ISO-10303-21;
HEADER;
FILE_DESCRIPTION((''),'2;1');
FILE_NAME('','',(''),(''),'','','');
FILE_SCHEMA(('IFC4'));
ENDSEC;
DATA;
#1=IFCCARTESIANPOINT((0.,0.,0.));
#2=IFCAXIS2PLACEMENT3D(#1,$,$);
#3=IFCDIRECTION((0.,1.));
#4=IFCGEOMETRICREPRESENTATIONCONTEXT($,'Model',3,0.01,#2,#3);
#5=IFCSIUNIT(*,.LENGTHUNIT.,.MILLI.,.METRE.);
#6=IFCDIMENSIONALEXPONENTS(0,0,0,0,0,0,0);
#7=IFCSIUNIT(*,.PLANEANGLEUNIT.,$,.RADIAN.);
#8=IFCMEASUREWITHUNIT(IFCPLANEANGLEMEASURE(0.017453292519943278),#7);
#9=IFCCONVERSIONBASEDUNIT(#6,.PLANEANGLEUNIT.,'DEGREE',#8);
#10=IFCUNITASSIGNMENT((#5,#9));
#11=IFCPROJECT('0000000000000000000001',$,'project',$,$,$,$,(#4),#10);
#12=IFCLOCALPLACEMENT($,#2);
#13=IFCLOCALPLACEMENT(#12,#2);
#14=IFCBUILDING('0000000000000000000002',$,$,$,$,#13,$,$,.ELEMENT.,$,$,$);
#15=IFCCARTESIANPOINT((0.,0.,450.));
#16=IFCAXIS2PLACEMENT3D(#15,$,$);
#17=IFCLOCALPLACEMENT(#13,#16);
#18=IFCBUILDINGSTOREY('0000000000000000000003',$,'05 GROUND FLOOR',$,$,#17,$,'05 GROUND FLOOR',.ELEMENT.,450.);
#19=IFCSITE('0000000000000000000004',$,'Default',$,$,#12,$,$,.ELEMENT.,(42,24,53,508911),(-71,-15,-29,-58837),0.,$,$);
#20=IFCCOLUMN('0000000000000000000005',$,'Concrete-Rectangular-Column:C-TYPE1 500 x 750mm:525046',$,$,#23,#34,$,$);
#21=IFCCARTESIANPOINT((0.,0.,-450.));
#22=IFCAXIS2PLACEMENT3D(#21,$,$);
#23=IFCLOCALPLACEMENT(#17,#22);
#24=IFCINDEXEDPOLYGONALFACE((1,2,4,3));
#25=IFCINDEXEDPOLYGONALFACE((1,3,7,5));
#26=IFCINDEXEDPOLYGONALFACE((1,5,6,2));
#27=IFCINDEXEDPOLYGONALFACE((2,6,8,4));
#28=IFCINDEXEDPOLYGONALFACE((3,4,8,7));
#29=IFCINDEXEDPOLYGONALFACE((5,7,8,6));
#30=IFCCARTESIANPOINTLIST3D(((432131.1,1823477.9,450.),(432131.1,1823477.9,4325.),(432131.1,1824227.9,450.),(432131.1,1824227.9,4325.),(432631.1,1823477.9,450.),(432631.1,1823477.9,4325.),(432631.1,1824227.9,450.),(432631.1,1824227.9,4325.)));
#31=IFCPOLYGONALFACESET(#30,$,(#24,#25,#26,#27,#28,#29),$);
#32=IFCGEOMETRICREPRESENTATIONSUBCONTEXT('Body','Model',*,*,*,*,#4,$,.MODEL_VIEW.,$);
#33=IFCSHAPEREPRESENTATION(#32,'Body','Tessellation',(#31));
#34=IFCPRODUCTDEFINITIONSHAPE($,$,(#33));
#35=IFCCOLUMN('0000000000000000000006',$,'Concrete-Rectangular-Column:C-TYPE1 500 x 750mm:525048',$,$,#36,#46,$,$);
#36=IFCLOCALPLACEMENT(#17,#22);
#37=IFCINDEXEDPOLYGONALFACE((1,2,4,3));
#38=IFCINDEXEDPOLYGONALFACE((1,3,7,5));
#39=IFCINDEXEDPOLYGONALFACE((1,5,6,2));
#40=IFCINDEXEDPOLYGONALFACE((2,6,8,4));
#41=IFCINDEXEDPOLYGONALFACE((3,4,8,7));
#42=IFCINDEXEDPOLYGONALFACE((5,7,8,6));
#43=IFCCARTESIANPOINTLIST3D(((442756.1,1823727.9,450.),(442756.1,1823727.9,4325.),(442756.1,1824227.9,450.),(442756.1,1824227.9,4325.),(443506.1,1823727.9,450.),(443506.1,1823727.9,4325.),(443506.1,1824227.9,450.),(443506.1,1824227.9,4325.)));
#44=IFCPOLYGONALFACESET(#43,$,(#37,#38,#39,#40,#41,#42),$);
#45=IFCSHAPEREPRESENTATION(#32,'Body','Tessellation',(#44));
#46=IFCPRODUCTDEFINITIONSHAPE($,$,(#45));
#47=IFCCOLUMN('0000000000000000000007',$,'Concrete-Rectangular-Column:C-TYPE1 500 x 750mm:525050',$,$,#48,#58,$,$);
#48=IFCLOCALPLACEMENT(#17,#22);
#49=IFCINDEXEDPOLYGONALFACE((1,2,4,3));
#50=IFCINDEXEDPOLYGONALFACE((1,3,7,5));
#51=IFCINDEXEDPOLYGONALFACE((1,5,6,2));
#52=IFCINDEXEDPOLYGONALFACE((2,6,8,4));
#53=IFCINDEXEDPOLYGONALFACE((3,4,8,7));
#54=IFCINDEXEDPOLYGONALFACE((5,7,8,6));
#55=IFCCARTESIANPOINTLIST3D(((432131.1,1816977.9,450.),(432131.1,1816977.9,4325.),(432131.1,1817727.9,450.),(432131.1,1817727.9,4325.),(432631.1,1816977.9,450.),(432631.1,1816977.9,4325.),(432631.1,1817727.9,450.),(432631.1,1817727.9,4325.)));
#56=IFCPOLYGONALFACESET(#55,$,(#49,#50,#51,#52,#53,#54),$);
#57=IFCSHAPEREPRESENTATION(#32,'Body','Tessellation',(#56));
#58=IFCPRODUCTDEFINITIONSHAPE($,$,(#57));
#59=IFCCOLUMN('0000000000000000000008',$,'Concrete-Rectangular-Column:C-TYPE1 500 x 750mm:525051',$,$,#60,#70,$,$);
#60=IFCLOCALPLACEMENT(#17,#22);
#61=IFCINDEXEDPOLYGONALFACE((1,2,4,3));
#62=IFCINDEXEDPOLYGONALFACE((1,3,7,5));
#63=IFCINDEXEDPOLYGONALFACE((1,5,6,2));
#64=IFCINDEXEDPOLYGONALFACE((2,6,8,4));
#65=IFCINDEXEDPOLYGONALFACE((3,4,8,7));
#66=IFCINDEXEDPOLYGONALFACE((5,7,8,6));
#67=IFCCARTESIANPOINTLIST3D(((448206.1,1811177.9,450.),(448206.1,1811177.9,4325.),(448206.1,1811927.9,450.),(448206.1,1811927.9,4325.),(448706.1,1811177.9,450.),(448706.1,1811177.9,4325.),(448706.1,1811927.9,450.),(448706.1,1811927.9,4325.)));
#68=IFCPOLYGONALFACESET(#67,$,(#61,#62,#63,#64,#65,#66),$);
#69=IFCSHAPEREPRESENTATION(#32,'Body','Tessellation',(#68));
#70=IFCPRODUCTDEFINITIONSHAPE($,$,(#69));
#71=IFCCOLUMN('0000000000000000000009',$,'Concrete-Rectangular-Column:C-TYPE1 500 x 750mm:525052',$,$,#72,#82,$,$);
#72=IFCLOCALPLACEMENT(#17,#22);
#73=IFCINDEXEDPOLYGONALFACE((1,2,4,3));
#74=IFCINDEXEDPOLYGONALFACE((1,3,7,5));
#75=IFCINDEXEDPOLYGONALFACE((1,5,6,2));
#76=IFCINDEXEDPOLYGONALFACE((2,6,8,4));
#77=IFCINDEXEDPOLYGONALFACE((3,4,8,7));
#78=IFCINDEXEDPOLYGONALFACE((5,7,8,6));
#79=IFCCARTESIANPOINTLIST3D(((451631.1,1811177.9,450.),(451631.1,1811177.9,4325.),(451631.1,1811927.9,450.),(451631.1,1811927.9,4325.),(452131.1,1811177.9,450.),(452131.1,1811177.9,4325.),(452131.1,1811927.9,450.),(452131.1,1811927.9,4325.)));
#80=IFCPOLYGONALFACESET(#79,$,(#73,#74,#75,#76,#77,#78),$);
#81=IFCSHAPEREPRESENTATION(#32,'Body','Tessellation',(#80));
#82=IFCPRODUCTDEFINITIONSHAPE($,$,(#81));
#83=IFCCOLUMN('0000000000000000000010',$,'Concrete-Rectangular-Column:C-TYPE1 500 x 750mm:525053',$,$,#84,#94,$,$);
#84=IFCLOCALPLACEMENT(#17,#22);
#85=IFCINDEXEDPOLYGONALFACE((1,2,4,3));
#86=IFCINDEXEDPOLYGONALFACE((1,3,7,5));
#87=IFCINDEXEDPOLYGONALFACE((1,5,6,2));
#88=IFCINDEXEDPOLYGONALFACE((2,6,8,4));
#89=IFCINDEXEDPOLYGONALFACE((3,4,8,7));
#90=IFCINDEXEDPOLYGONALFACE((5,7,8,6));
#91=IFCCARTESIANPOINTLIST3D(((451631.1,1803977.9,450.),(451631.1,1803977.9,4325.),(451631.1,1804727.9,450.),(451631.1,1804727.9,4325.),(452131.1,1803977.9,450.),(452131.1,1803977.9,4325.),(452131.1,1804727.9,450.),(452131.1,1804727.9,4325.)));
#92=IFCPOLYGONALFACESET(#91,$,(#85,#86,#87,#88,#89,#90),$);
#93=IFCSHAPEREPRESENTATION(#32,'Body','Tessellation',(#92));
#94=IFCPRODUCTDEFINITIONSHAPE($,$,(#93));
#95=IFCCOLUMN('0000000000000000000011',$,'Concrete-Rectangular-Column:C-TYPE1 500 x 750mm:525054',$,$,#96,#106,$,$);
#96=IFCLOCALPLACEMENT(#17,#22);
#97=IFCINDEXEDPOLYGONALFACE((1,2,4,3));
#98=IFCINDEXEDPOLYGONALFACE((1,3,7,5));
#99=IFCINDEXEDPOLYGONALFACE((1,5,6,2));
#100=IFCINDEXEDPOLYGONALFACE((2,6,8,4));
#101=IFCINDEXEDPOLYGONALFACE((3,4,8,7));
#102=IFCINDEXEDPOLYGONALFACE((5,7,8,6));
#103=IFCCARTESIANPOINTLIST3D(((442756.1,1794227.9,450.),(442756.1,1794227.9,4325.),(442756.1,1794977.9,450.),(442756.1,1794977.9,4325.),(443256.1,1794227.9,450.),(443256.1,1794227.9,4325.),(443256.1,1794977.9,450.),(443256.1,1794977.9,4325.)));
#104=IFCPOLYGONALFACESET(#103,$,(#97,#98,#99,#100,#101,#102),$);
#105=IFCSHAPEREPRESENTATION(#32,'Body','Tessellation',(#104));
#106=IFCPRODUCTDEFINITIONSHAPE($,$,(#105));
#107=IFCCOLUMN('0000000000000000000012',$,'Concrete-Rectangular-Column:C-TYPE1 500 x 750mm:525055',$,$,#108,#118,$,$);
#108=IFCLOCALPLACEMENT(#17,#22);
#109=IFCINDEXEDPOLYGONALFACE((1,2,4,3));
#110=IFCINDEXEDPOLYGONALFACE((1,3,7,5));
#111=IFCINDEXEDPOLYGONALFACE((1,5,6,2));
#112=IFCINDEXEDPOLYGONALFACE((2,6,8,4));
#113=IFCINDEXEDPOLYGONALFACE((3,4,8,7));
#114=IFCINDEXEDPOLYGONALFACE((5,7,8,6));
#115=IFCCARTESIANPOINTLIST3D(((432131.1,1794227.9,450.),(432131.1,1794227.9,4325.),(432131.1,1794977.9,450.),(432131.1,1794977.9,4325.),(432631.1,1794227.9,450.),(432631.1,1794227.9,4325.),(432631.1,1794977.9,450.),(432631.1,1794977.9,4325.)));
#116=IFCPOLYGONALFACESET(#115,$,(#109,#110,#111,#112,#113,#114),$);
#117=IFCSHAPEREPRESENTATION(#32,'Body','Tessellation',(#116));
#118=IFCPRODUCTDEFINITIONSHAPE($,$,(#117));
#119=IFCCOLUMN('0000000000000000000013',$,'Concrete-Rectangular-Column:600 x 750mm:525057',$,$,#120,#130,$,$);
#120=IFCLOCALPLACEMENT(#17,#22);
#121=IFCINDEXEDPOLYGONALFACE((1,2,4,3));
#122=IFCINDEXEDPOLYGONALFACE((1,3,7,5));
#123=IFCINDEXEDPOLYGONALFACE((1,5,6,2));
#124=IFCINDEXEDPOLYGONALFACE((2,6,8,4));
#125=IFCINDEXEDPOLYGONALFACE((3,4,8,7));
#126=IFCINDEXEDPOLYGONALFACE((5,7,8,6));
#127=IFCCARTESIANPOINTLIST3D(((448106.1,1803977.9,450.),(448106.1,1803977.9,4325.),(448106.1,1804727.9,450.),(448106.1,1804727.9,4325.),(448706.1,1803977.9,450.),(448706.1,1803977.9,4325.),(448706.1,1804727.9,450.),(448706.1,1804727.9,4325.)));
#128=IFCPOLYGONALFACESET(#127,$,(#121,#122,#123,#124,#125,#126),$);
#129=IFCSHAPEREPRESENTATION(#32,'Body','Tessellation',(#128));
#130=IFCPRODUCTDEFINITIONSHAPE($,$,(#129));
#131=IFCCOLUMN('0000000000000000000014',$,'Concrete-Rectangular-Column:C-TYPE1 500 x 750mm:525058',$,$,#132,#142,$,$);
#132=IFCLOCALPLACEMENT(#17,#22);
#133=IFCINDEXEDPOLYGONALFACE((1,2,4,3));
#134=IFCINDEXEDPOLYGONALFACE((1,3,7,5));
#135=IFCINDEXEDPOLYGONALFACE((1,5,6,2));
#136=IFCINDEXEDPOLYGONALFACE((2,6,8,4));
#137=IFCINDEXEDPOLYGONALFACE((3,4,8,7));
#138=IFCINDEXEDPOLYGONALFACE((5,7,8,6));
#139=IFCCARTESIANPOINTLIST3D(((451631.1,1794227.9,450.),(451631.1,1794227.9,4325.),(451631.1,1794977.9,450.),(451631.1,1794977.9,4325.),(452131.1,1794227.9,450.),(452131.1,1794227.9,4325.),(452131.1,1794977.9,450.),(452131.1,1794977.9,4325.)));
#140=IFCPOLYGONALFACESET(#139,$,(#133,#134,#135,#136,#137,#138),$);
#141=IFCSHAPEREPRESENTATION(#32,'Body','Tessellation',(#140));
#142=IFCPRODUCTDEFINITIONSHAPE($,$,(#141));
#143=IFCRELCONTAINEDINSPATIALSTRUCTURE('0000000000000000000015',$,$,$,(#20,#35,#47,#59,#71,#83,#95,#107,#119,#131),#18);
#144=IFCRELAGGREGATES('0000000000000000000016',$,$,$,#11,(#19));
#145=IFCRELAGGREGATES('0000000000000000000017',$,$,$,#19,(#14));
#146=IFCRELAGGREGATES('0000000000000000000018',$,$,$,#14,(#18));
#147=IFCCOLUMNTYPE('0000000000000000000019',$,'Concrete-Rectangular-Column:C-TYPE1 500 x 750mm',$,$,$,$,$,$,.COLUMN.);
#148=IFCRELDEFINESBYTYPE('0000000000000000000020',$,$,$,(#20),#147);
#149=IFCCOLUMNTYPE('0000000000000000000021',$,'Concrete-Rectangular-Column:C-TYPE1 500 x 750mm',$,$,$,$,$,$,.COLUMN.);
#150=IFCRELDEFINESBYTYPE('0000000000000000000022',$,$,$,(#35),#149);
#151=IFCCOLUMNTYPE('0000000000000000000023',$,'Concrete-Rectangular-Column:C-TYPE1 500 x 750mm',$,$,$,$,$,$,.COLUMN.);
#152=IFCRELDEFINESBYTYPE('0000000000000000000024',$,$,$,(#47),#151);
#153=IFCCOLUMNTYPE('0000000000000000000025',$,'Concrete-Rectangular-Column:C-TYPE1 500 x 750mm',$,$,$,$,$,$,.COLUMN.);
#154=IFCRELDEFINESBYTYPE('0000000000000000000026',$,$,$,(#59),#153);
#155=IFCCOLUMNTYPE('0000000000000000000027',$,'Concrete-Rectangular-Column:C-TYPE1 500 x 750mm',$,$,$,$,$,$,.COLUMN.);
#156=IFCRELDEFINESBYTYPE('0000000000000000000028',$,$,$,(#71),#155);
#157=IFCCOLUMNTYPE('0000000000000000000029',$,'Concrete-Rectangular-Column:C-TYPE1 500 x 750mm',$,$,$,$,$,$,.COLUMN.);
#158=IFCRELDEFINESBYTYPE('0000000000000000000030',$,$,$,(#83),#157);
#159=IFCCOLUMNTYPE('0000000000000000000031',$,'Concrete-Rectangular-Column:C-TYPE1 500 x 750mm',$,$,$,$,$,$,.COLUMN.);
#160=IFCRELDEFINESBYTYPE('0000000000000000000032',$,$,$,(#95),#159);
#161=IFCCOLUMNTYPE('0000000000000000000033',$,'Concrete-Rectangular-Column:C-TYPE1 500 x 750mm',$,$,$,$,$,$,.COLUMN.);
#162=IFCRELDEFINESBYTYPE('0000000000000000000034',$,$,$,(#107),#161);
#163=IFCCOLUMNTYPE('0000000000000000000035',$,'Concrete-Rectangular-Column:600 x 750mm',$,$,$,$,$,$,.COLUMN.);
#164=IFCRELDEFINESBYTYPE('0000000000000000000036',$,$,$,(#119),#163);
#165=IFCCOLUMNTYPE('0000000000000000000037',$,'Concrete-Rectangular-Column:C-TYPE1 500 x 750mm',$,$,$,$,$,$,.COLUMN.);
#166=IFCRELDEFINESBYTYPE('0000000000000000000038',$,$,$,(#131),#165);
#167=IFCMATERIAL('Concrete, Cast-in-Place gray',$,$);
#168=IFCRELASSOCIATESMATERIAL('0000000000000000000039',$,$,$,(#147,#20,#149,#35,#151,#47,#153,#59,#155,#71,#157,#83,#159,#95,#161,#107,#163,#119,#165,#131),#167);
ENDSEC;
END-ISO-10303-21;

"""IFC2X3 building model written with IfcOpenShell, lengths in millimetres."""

from ifc_helpers import new_model, entity, si_unit, converted_unit, direction, frame, frame_2d, origin, place, context, subcontext, project, spatial, rectangle, extrude, source, transform, mapped, material, type_object, type_shapes, element, save


model = new_model("IFC2X3")

# Units and contexts
model_context = context("Model", 3, precision=0.01, world=origin(), true_north=direction((0.0, 1.0)))
body_context = subcontext(model_context, "Body", "Model", "MODEL_VIEW")
ifc_project = project(units=[si_unit("LENGTHUNIT", "METRE", prefix="MILLI"), converted_unit("PLANEANGLEUNIT", "DEGREE", entity("IfcPlaneAngleMeasure", 0.017453292519943278), si_unit("PLANEANGLEUNIT", "RADIAN"), dimensions=[0, 0, 0, 0, 0, 0, 0])], contexts=[model_context])

# Site, building, storey
site_placement = place(None, origin())
site = spatial("IfcSite", under=ifc_project, at=site_placement, Name="Default", CompositionType="ELEMENT", RefLatitude=(42, 24, 53, 508911), RefLongitude=(-71, -15, -29, -58837), RefElevation=0.0)
building_placement = place(site_placement, origin())
building = spatial("IfcBuilding", under=site, at=building_placement, CompositionType="ELEMENT")
storey_placement = place(building_placement, frame((0.0, 0.0, 450.0)))
storey = spatial("IfcBuildingStorey", under=building, at=storey_placement, Name="05 GROUND FLOOR", LongName="05 GROUND FLOOR", CompositionType="ELEMENT", Elevation=450.0)

# Columns
ifc_material_1 = material(Name="Concrete, Cast-in-Place gray")
column_type_1 = type_object("IfcColumnType", Name="Concrete-Rectangular-Column:C-TYPE1 500 x 750mm", PredefinedType="COLUMN", material=ifc_material_1)
shared_shape_1 = source(origin(), body_context, "Body", "SweptSolid", [
    extrude(rectangle(XDim=3875.0, YDim=750.0, at=frame_2d((0.0, 0.0), x_axis=(1.0, 0.0))), frame((432131.1, 1823852.9, 2387.5), z_axis=(1.0, 0.0, 0.0), x_axis=(0.0, 0.0, 1.0)), (0.0, 0.0, 1.0), 500.0),
])
type_shapes(column_type_1, [shared_shape_1])
column_1_placement = place(storey_placement, frame((0.0, 0.0, -450.0)))
element("IfcColumn", 1, at=column_1_placement, inside=storey, type_object=column_type_1, material=ifc_material_1, Name="Concrete-Rectangular-Column:C-TYPE1 500 x 750mm:525046", context=body_context, shape_type="MappedRepresentation", body=[
    mapped(shared_shape_1, transform((0.0, 0.0, 0.0), scale=1.0)),
])
column_type_2 = type_object("IfcColumnType", Name="Concrete-Rectangular-Column:C-TYPE1 500 x 750mm", PredefinedType="COLUMN", material=ifc_material_1)
shared_shape_2 = source(origin(), body_context, "Body", "SweptSolid", [
    extrude(rectangle(XDim=500.0, YDim=750.0, at=frame_2d((0.0, 0.0), x_axis=(1.0, 0.0))), frame((443131.1, 1823977.9, 450.0), z_axis=(0.0, 0.0, 1.0), x_axis=(0.0, -1.0, 0.0)), (0.0, 0.0, 1.0), 3875.0),
])
type_shapes(column_type_2, [shared_shape_2])
column_2_placement = place(storey_placement, frame((0.0, 0.0, -450.0)))
element("IfcColumn", 2, at=column_2_placement, inside=storey, type_object=column_type_2, material=ifc_material_1, Name="Concrete-Rectangular-Column:C-TYPE1 500 x 750mm:525048", context=body_context, shape_type="MappedRepresentation", body=[
    mapped(shared_shape_2, transform((0.0, 0.0, 0.0), scale=1.0)),
])
column_type_3 = type_object("IfcColumnType", Name="Concrete-Rectangular-Column:C-TYPE1 500 x 750mm", PredefinedType="COLUMN", material=ifc_material_1)
shared_shape_3 = source(origin(), body_context, "Body", "SweptSolid", [
    extrude(rectangle(XDim=3875.0, YDim=750.0, at=frame_2d((0.0, 0.0), x_axis=(1.0, 0.0))), frame((432131.1, 1817352.9, 2387.5), z_axis=(1.0, 0.0, 0.0), x_axis=(0.0, 0.0, 1.0)), (0.0, 0.0, 1.0), 500.0),
])
type_shapes(column_type_3, [shared_shape_3])
column_3_placement = place(storey_placement, frame((0.0, 0.0, -450.0)))
element("IfcColumn", 3, at=column_3_placement, inside=storey, type_object=column_type_3, material=ifc_material_1, Name="Concrete-Rectangular-Column:C-TYPE1 500 x 750mm:525050", context=body_context, shape_type="MappedRepresentation", body=[
    mapped(shared_shape_3, transform((0.0, 0.0, 0.0), scale=1.0)),
])
column_type_4 = type_object("IfcColumnType", Name="Concrete-Rectangular-Column:C-TYPE1 500 x 750mm", PredefinedType="COLUMN", material=ifc_material_1)
shared_shape_4 = source(origin(), body_context, "Body", "SweptSolid", [
    extrude(rectangle(XDim=3875.0, YDim=750.0, at=frame_2d((0.0, 0.0), x_axis=(1.0, 0.0))), frame((448206.1, 1811552.9, 2387.5), z_axis=(1.0, 0.0, 0.0), x_axis=(0.0, 0.0, 1.0)), (0.0, 0.0, 1.0), 500.0),
])
type_shapes(column_type_4, [shared_shape_4])
column_4_placement = place(storey_placement, frame((0.0, 0.0, -450.0)))
element("IfcColumn", 4, at=column_4_placement, inside=storey, type_object=column_type_4, material=ifc_material_1, Name="Concrete-Rectangular-Column:C-TYPE1 500 x 750mm:525051", context=body_context, shape_type="MappedRepresentation", body=[
    mapped(shared_shape_4, transform((0.0, 0.0, 0.0), scale=1.0)),
])
column_type_5 = type_object("IfcColumnType", Name="Concrete-Rectangular-Column:C-TYPE1 500 x 750mm", PredefinedType="COLUMN", material=ifc_material_1)
shared_shape_5 = source(origin(), body_context, "Body", "SweptSolid", [
    extrude(rectangle(XDim=3875.0, YDim=750.0, at=frame_2d((0.0, 0.0), x_axis=(1.0, 0.0))), frame((451631.1, 1811552.9, 2387.5), z_axis=(1.0, 0.0, 0.0), x_axis=(0.0, 0.0, 1.0)), (0.0, 0.0, 1.0), 500.0),
])
type_shapes(column_type_5, [shared_shape_5])
column_5_placement = place(storey_placement, frame((0.0, 0.0, -450.0)))
element("IfcColumn", 5, at=column_5_placement, inside=storey, type_object=column_type_5, material=ifc_material_1, Name="Concrete-Rectangular-Column:C-TYPE1 500 x 750mm:525052", context=body_context, shape_type="MappedRepresentation", body=[
    mapped(shared_shape_5, transform((0.0, 0.0, 0.0), scale=1.0)),
])
column_type_6 = type_object("IfcColumnType", Name="Concrete-Rectangular-Column:C-TYPE1 500 x 750mm", PredefinedType="COLUMN", material=ifc_material_1)
shared_shape_6 = source(origin(), body_context, "Body", "SweptSolid", [
    extrude(rectangle(XDim=3875.0, YDim=750.0, at=frame_2d((0.0, 0.0), x_axis=(1.0, 0.0))), frame((451631.1, 1804352.9, 2387.5), z_axis=(1.0, 0.0, 0.0), x_axis=(0.0, 0.0, 1.0)), (0.0, 0.0, 1.0), 500.0),
])
type_shapes(column_type_6, [shared_shape_6])
column_6_placement = place(storey_placement, frame((0.0, 0.0, -450.0)))
element("IfcColumn", 6, at=column_6_placement, inside=storey, type_object=column_type_6, material=ifc_material_1, Name="Concrete-Rectangular-Column:C-TYPE1 500 x 750mm:525053", context=body_context, shape_type="MappedRepresentation", body=[
    mapped(shared_shape_6, transform((0.0, 0.0, 0.0), scale=1.0)),
])
column_type_7 = type_object("IfcColumnType", Name="Concrete-Rectangular-Column:C-TYPE1 500 x 750mm", PredefinedType="COLUMN", material=ifc_material_1)
shared_shape_7 = source(origin(), body_context, "Body", "SweptSolid", [
    extrude(rectangle(XDim=3875.0, YDim=750.0, at=frame_2d((0.0, 0.0), x_axis=(1.0, 0.0))), frame((442756.1, 1794602.9, 2387.5), z_axis=(1.0, 0.0, 0.0), x_axis=(0.0, 0.0, 1.0)), (0.0, 0.0, 1.0), 500.0),
])
type_shapes(column_type_7, [shared_shape_7])
column_7_placement = place(storey_placement, frame((0.0, 0.0, -450.0)))
element("IfcColumn", 7, at=column_7_placement, inside=storey, type_object=column_type_7, material=ifc_material_1, Name="Concrete-Rectangular-Column:C-TYPE1 500 x 750mm:525054", context=body_context, shape_type="MappedRepresentation", body=[
    mapped(shared_shape_7, transform((0.0, 0.0, 0.0), scale=1.0)),
])
column_type_8 = type_object("IfcColumnType", Name="Concrete-Rectangular-Column:C-TYPE1 500 x 750mm", PredefinedType="COLUMN", material=ifc_material_1)
shared_shape_8 = source(origin(), body_context, "Body", "SweptSolid", [
    extrude(rectangle(XDim=3875.0, YDim=750.0, at=frame_2d((0.0, 0.0), x_axis=(1.0, 0.0))), frame((432131.1, 1794602.9, 2387.5), z_axis=(1.0, 0.0, 0.0), x_axis=(0.0, 0.0, 1.0)), (0.0, 0.0, 1.0), 500.0),
])
type_shapes(column_type_8, [shared_shape_8])
column_8_placement = place(storey_placement, frame((0.0, 0.0, -450.0)))
element("IfcColumn", 8, at=column_8_placement, inside=storey, type_object=column_type_8, material=ifc_material_1, Name="Concrete-Rectangular-Column:C-TYPE1 500 x 750mm:525055", context=body_context, shape_type="MappedRepresentation", body=[
    mapped(shared_shape_8, transform((0.0, 0.0, 0.0), scale=1.0)),
])
column_type_9 = type_object("IfcColumnType", Name="Concrete-Rectangular-Column:600 x 750mm", PredefinedType="COLUMN", material=ifc_material_1)
shared_shape_9 = source(origin(), body_context, "Body", "SweptSolid", [
    extrude(rectangle(XDim=3875.0, YDim=750.0, at=frame_2d((0.0, 0.0), x_axis=(1.0, 0.0))), frame((448106.1, 1804352.9, 2387.5), z_axis=(1.0, 0.0, 0.0), x_axis=(0.0, 0.0, 1.0)), (0.0, 0.0, 1.0), 600.0),
])
type_shapes(column_type_9, [shared_shape_9])
column_9_placement = place(storey_placement, frame((0.0, 0.0, -450.0)))
element("IfcColumn", 9, at=column_9_placement, inside=storey, type_object=column_type_9, material=ifc_material_1, Name="Concrete-Rectangular-Column:600 x 750mm:525057", context=body_context, shape_type="MappedRepresentation", body=[
    mapped(shared_shape_9, transform((0.0, 0.0, 0.0), scale=1.0)),
])
column_type_10 = type_object("IfcColumnType", Name="Concrete-Rectangular-Column:C-TYPE1 500 x 750mm", PredefinedType="COLUMN", material=ifc_material_1)
shared_shape_10 = source(origin(), body_context, "Body", "SweptSolid", [
    extrude(rectangle(XDim=3875.0, YDim=750.0, at=frame_2d((0.0, 0.0), x_axis=(1.0, 0.0))), frame((451631.1, 1794602.9, 2387.5), z_axis=(1.0, 0.0, 0.0), x_axis=(0.0, 0.0, 1.0)), (0.0, 0.0, 1.0), 500.0),
])
type_shapes(column_type_10, [shared_shape_10])
column_10_placement = place(storey_placement, frame((0.0, 0.0, -450.0)))
element("IfcColumn", 10, at=column_10_placement, inside=storey, type_object=column_type_10, material=ifc_material_1, Name="Concrete-Rectangular-Column:C-TYPE1 500 x 750mm:525058", context=body_context, shape_type="MappedRepresentation", body=[
    mapped(shared_shape_10, transform((0.0, 0.0, 0.0), scale=1.0)),
])

save(model, "model.ifc")
